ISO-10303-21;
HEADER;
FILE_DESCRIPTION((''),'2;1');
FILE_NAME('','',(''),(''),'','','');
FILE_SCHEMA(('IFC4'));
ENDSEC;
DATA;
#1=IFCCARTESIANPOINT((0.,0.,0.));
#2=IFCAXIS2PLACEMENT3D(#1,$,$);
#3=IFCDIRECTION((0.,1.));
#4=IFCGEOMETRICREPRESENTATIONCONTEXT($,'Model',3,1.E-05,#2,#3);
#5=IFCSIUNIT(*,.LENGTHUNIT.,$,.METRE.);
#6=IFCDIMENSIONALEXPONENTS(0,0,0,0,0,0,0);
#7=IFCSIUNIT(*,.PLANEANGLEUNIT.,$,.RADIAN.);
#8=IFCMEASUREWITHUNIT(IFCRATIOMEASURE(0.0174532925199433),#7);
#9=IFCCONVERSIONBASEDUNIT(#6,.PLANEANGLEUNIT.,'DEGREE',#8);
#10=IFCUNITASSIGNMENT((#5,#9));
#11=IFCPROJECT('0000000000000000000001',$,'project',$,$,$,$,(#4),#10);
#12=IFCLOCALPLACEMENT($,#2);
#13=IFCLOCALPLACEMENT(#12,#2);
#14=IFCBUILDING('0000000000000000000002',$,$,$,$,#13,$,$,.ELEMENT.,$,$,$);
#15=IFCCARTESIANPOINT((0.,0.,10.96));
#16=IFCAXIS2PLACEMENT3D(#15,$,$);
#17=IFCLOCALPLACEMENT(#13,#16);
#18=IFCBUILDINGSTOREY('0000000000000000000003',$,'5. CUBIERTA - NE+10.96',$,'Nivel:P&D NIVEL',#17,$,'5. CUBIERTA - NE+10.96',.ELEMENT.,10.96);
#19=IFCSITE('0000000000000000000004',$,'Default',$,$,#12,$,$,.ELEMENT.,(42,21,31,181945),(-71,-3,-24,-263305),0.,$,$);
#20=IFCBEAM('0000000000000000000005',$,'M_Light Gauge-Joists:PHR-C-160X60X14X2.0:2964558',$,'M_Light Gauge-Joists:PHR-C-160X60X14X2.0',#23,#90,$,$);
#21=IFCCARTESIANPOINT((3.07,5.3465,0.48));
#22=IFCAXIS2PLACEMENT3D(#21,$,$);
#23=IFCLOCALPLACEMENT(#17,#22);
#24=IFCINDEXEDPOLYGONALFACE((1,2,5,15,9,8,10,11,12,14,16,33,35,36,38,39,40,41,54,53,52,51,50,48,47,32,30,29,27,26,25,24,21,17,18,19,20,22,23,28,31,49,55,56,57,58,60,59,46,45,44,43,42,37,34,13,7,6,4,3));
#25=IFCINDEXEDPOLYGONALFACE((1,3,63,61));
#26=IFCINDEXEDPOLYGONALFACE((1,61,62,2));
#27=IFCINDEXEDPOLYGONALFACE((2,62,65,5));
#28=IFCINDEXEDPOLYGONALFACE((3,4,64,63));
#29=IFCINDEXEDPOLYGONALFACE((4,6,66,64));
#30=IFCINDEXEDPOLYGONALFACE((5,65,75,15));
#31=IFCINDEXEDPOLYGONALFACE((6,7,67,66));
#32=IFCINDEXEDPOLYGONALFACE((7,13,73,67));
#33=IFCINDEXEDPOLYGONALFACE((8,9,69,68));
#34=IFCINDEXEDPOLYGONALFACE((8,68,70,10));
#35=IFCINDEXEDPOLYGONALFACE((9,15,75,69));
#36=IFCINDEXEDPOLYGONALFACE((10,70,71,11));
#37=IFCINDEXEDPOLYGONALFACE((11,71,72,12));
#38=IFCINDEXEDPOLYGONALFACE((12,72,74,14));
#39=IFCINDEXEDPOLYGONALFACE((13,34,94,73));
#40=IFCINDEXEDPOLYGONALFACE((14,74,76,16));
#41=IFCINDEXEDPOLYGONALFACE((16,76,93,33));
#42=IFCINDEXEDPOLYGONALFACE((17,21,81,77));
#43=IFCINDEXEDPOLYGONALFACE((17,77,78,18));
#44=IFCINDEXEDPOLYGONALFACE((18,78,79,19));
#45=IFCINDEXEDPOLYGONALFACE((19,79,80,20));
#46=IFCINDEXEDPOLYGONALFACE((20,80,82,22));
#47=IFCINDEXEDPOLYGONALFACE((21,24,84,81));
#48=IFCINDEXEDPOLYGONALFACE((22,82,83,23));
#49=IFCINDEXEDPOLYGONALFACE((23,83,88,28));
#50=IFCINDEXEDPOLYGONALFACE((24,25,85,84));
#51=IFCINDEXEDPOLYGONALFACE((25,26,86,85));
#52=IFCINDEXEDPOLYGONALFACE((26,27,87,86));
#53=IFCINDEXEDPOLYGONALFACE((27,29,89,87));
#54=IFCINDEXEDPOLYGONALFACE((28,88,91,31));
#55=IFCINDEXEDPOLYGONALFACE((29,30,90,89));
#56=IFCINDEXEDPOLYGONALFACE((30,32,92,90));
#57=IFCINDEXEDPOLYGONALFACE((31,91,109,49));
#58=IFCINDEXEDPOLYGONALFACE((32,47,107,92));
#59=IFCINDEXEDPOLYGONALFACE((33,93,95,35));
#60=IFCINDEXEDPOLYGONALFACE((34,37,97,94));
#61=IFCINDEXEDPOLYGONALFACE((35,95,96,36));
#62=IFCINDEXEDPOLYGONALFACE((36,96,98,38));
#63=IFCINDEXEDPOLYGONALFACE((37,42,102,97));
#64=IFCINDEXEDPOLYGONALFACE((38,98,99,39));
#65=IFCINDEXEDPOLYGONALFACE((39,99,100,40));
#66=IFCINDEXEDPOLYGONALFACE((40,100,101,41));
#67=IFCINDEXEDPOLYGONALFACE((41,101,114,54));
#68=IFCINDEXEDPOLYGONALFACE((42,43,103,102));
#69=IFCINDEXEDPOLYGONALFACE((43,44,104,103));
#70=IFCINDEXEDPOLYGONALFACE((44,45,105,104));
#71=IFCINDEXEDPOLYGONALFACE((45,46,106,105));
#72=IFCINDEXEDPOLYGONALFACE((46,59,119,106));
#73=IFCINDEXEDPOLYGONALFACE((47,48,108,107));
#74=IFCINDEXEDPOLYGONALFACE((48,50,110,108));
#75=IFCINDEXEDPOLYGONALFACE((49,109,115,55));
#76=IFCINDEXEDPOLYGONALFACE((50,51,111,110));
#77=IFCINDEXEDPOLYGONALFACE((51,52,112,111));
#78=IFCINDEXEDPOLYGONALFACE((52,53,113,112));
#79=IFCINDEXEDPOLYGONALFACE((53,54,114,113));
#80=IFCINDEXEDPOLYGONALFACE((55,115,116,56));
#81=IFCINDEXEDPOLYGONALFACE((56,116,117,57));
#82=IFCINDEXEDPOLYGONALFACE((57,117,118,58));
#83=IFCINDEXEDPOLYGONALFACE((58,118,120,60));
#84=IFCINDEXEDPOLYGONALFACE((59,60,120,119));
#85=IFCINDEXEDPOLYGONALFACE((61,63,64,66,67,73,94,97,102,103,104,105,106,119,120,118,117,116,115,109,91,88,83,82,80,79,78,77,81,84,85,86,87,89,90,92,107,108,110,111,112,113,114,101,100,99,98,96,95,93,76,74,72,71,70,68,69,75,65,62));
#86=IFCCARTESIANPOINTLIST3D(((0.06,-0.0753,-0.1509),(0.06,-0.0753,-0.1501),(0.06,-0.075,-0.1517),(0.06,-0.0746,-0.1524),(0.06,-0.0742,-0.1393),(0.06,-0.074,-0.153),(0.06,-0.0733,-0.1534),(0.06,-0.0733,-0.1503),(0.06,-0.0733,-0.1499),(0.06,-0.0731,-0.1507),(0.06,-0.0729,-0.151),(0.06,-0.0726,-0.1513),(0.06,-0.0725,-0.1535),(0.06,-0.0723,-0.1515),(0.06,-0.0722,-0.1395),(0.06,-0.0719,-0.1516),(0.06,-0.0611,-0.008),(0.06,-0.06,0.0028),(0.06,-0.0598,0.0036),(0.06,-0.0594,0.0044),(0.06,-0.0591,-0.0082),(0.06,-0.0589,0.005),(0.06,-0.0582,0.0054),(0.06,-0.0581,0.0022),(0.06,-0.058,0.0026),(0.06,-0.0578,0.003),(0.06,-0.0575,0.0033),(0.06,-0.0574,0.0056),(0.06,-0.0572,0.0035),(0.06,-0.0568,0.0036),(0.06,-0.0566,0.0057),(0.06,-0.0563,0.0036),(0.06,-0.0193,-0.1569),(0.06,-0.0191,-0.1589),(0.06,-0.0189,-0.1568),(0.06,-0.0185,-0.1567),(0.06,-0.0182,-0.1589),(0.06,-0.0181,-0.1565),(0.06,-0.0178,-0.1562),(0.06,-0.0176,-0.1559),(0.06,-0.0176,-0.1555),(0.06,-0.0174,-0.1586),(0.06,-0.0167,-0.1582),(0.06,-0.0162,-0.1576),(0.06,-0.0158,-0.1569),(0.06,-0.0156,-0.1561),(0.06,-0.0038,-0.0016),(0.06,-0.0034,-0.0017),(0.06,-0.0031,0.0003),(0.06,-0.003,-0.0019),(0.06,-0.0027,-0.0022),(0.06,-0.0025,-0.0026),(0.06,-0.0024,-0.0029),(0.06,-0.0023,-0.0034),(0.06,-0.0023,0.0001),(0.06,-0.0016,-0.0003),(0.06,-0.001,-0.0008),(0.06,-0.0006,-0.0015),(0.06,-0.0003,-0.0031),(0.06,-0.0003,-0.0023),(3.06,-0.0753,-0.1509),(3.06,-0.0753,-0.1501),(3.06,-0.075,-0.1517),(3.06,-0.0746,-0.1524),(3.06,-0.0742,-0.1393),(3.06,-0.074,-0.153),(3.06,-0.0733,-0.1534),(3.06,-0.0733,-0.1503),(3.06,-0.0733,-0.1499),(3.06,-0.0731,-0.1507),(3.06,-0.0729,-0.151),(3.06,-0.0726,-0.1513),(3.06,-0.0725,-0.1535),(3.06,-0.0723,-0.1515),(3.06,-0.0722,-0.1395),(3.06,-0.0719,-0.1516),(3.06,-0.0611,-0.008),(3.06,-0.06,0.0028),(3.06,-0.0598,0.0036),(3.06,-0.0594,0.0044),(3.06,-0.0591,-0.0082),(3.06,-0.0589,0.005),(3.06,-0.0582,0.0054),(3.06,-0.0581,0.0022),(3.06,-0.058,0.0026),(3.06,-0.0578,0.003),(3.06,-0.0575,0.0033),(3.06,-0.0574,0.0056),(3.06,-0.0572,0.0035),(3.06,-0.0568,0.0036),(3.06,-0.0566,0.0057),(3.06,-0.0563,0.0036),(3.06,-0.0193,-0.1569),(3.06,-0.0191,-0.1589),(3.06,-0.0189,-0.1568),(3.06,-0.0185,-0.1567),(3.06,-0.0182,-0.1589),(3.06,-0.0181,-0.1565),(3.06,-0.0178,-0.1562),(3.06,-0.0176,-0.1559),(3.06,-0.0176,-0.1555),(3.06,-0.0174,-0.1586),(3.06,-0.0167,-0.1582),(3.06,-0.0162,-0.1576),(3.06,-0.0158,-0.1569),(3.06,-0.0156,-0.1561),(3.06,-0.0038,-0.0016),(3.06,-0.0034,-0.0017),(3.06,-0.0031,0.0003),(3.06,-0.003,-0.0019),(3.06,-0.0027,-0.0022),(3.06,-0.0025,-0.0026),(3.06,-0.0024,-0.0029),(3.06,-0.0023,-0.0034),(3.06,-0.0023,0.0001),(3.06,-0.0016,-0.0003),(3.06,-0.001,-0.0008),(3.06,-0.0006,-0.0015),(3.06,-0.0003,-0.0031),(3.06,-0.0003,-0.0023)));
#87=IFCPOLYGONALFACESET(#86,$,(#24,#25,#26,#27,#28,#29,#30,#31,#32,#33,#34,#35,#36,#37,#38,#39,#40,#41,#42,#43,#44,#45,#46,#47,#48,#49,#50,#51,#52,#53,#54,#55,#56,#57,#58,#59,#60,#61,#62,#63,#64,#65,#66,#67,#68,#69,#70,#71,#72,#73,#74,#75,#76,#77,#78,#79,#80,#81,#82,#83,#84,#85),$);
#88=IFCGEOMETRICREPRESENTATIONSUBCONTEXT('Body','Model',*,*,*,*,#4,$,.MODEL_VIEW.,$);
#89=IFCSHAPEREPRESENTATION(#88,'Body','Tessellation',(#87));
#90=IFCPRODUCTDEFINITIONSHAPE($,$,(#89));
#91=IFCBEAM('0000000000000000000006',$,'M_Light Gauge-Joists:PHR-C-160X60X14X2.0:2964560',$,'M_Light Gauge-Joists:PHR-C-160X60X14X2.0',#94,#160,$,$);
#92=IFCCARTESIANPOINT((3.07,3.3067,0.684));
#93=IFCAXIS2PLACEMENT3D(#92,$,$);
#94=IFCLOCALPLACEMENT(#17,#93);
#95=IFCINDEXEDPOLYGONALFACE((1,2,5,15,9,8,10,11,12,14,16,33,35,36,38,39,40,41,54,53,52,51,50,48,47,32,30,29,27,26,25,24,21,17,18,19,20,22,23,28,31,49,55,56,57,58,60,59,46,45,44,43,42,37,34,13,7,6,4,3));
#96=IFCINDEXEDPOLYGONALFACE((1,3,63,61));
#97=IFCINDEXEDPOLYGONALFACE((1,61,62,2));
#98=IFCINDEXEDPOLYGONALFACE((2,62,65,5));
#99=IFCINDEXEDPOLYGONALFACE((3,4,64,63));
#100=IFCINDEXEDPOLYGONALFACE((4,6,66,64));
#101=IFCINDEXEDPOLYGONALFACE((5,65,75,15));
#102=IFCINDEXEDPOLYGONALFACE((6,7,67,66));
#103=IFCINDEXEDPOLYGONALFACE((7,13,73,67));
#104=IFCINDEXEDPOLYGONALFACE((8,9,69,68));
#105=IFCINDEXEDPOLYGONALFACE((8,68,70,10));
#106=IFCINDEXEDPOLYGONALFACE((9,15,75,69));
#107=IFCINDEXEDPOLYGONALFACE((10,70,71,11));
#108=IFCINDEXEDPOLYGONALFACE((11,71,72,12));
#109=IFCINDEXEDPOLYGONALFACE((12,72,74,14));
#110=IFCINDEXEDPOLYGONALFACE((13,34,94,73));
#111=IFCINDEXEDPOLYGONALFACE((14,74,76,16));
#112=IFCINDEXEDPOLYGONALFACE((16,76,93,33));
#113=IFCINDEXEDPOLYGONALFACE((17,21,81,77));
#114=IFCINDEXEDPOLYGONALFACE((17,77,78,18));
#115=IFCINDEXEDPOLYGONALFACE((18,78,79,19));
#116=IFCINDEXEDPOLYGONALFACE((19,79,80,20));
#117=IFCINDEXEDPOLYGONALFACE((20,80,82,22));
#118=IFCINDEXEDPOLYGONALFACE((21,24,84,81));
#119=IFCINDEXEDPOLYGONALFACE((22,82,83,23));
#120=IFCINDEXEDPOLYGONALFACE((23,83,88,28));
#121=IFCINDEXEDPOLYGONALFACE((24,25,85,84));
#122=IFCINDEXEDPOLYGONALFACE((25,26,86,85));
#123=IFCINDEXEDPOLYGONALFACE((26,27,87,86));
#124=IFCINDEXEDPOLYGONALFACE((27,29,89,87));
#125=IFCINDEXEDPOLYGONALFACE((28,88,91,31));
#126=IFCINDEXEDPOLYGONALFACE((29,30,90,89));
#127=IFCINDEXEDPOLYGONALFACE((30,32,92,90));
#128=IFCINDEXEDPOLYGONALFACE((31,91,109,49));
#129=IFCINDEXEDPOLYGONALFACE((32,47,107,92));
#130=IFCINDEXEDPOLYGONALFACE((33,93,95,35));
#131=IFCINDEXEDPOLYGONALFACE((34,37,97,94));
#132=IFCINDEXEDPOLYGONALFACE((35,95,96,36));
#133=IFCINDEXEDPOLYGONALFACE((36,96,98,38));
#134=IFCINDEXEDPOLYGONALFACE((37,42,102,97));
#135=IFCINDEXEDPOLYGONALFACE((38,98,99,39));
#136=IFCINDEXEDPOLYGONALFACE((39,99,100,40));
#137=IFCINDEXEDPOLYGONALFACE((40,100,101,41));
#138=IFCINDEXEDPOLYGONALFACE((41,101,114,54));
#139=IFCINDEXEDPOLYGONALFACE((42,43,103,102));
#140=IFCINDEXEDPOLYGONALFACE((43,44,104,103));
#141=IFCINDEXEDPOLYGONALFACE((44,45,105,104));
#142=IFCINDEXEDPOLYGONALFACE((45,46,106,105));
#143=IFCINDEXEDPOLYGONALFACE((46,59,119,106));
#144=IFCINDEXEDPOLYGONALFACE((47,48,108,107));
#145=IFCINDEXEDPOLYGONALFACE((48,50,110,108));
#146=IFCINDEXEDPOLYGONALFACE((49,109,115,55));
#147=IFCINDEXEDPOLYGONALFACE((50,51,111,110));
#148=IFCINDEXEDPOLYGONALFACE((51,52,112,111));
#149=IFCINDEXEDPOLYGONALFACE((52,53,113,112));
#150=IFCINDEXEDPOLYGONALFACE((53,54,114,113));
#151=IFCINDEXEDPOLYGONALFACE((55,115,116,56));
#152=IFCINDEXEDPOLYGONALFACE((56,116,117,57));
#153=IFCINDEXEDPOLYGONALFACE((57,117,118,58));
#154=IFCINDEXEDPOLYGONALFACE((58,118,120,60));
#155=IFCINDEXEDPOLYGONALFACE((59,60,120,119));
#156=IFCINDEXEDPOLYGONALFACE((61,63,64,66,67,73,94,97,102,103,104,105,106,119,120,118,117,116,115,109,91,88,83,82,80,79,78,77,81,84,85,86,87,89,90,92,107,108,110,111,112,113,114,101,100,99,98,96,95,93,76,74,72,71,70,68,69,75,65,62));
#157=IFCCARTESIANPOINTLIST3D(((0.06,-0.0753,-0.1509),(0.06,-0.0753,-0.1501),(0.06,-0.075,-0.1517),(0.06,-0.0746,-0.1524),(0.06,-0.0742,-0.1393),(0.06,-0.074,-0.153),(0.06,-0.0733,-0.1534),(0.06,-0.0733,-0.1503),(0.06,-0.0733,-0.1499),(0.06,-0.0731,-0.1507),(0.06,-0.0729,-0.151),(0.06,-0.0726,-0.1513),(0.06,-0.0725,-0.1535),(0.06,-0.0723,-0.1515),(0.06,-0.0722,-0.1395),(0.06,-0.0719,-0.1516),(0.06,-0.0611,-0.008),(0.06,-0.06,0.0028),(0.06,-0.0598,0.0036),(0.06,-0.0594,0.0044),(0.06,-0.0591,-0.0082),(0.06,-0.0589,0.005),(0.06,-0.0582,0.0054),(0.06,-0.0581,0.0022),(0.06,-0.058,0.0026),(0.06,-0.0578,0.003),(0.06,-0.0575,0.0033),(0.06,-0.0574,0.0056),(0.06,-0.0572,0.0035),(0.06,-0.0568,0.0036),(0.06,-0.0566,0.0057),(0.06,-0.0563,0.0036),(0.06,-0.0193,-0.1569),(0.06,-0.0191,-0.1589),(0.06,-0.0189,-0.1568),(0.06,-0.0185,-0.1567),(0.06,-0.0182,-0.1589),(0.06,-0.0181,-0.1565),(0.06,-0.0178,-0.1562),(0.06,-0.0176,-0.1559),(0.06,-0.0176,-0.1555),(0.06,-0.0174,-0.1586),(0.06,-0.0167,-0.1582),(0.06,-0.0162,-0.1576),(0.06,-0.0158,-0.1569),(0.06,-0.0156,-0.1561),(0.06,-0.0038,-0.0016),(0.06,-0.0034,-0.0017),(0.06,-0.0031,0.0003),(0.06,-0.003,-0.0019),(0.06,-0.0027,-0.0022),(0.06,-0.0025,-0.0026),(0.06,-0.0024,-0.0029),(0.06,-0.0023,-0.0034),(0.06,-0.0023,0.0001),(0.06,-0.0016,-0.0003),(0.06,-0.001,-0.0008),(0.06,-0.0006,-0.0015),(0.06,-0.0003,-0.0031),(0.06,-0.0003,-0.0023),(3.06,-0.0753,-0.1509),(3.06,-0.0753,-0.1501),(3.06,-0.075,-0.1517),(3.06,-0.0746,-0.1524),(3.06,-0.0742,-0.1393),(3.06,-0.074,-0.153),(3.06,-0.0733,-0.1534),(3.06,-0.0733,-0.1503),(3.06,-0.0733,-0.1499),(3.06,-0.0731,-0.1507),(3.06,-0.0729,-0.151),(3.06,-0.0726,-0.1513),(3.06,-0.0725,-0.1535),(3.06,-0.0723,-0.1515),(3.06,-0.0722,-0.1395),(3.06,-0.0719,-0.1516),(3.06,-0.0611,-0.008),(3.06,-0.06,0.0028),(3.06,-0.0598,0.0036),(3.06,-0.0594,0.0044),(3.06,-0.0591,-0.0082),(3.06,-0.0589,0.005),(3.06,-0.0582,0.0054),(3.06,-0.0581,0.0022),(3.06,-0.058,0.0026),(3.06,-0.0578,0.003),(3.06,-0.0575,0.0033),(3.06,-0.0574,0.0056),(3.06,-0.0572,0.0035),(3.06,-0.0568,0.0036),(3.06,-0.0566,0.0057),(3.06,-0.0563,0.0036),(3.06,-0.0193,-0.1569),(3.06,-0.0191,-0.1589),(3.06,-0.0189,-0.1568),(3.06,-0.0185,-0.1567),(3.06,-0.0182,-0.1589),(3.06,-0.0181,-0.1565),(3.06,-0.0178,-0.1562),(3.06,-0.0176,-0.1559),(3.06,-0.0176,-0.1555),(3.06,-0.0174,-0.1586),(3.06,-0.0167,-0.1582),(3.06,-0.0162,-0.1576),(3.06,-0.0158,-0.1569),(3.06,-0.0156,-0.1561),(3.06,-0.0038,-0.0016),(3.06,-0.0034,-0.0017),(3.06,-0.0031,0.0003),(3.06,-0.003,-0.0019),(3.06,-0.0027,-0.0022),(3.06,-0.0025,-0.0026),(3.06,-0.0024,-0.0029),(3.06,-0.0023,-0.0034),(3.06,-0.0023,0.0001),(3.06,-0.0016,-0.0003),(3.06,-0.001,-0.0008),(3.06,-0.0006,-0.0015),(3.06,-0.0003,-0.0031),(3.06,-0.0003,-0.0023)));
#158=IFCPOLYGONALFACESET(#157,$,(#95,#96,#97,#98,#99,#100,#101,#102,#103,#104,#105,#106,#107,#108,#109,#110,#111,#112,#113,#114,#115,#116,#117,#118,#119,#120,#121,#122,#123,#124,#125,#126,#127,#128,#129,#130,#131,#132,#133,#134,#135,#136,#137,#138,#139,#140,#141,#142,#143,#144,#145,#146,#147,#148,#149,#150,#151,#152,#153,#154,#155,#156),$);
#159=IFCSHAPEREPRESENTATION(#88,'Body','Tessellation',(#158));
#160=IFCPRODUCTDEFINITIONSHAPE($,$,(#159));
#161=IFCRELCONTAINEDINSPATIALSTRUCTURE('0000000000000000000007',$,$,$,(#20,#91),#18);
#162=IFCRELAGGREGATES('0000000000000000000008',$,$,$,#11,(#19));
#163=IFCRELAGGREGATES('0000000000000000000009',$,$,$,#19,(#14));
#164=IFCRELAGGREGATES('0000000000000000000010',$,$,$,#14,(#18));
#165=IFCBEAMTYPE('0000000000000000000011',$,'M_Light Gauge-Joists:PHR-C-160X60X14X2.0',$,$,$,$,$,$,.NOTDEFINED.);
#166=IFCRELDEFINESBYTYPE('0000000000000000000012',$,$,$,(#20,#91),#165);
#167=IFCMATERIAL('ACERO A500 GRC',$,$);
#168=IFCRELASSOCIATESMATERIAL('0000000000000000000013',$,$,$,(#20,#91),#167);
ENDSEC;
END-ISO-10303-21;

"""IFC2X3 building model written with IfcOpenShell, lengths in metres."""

from ifc_helpers import new_model, entity, si_unit, converted_unit, direction, frame, frame_2d, origin, place, context, subcontext, project, spatial, polyline, circle_curve, parameter, trimmed, segment, composite_curve, outline, extrude, material, type_object, element, save


model = new_model("IFC2X3")

# Units and contexts
model_context = context("Model", 3, precision=1e-05, world=origin(), true_north=direction((0.0, 1.0)))
body_context = subcontext(model_context, "Body", "Model", "MODEL_VIEW")
ifc_project = project(units=[si_unit("LENGTHUNIT", "METRE"), converted_unit("PLANEANGLEUNIT", "DEGREE", entity("IfcRatioMeasure", 0.0174532925199433), si_unit("PLANEANGLEUNIT", "RADIAN"), dimensions=[0, 0, 0, 0, 0, 0, 0])], contexts=[model_context])

# Site, building, storey
site_placement = place(None, origin())
site = spatial("IfcSite", under=ifc_project, at=site_placement, Name="Default", CompositionType="ELEMENT", RefLatitude=(42, 21, 31, 181945), RefLongitude=(-71, -3, -24, -263305), RefElevation=0.0)
building_placement = place(site_placement, origin())
building = spatial("IfcBuilding", under=site, at=building_placement, CompositionType="ELEMENT")
storey_placement = place(building_placement, frame((0.0, 0.0, 10.96)))
storey = spatial("IfcBuildingStorey", under=building, at=storey_placement, Name="5. CUBIERTA - NE+10.96", ObjectType="Nivel:P&D NIVEL", LongName="5. CUBIERTA - NE+10.96", CompositionType="ELEMENT", Elevation=10.96)

# Beams
ifc_material_1 = material(Name="ACERO A500 GRC")
beam_type_1 = type_object("IfcBeamType", Name="M_Light Gauge-Joists:PHR-C-160X60X14X2.0", PredefinedType="NOTDEFINED")
beam_1_placement = place(storey_placement, frame((3.07, 5.3465, 0.48)))
element("IfcBeam", 1, at=beam_1_placement, inside=storey, type_object=beam_type_1, material=ifc_material_1, Name="M_Light Gauge-Joists:PHR-C-160X60X14X2.0:2964558", ObjectType="M_Light Gauge-Joists:PHR-C-160X60X14X2.0", context=body_context, shape_type="SweptSolid", body=[
    extrude(outline(composite_curve([segment(polyline([(-0.0768, -0.0358), (0.0768, -0.0358)]), True, "CONTINUOUS"), segment(trimmed(circle_curve(frame_2d((0.0768, -0.0326), x_axis=(0.0, -1.0)), 0.0032), [parameter(0.0)], [parameter(90.0)], True, "PARAMETER"), True, "CONTINUOUS"), segment(polyline([(0.08, -0.0326), (0.08, 0.021)]), True, "CONTINUOUS"), segment(trimmed(circle_curve(frame_2d((0.0768, 0.021), x_axis=(1.0, 0.0)), 0.0032), [parameter(0.0)], [parameter(90.0)], True, "PARAMETER"), True, "CONTINUOUS"), segment(polyline([(0.0768, 0.0242), (0.066, 0.0242)]), True, "CONTINUOUS"), segment(polyline([(0.066, 0.0242), (0.066, 0.0222)]), True, "CONTINUOUS"), segment(polyline([(0.066, 0.0222), (0.0764, 0.0222)]), True, "CONTINUOUS"), segment(trimmed(circle_curve(frame_2d((0.0764, 0.0206), x_axis=(0.0, 1.0)), 0.0016), [parameter(270.0)], [parameter(0.0)], True, "PARAMETER"), False, "CONTINUOUS"), segment(polyline([(0.078, 0.0206), (0.078, -0.0322)]), True, "CONTINUOUS"), segment(trimmed(circle_curve(frame_2d((0.0764, -0.0322), x_axis=(1.0, 0.0)), 0.0016), [parameter(270.0)], [parameter(0.0)], True, "PARAMETER"), False, "CONTINUOUS"), segment(polyline([(0.0764, -0.0338), (-0.0764, -0.0338)]), True, "CONTINUOUS"), segment(trimmed(circle_curve(frame_2d((-0.0764, -0.0322), x_axis=(0.0, -1.0)), 0.0016), [parameter(270.0)], [parameter(0.0)], True, "PARAMETER"), False, "CONTINUOUS"), segment(polyline([(-0.078, -0.0322), (-0.078, 0.0206)]), True, "CONTINUOUS"), segment(trimmed(circle_curve(frame_2d((-0.0764, 0.0206), x_axis=(-1.0, 0.0)), 0.0016), [parameter(270.0)], [parameter(0.0)], True, "PARAMETER"), False, "CONTINUOUS"), segment(polyline([(-0.0764, 0.0222), (-0.066, 0.0222)]), True, "CONTINUOUS"), segment(polyline([(-0.066, 0.0222), (-0.066, 0.0242)]), True, "CONTINUOUS"), segment(polyline([(-0.066, 0.0242), (-0.0768, 0.0242)]), True, "CONTINUOUS"), segment(trimmed(circle_curve(frame_2d((-0.0768, 0.021), x_axis=(0.0, 1.0)), 0.0032), [parameter(0.0)], [parameter(90.0)], True, "PARAMETER"), True, "CONTINUOUS"), segment(polyline([(-0.08, 0.021), (-0.08, -0.0326)]), True, "CONTINUOUS"), segment(trimmed(circle_curve(frame_2d((-0.0768, -0.0326), x_axis=(-1.0, 0.0)), 0.0032), [parameter(0.0)], [parameter(90.0)], True, "PARAMETER"), True, "CONTINUOUS")], self_intersect=False)), frame((0.06, -0.0436, -0.076), z_axis=(1.0, 0.0, 0.0), x_axis=(0.0, 0.099504, 0.995037)), (0.0, 0.0, 1.0), 3.0),
])
beam_2_placement = place(storey_placement, frame((3.07, 3.3067, 0.684)))
element("IfcBeam", 2, at=beam_2_placement, inside=storey, type_object=beam_type_1, material=ifc_material_1, Name="M_Light Gauge-Joists:PHR-C-160X60X14X2.0:2964560", ObjectType="M_Light Gauge-Joists:PHR-C-160X60X14X2.0", context=body_context, shape_type="SweptSolid", body=[
    extrude(outline(composite_curve([segment(polyline([(-0.0768, -0.0358), (0.0768, -0.0358)]), True, "CONTINUOUS"), segment(trimmed(circle_curve(frame_2d((0.0768, -0.0326), x_axis=(0.0, -1.0)), 0.0032), [parameter(0.0)], [parameter(90.0)], True, "PARAMETER"), True, "CONTINUOUS"), segment(polyline([(0.08, -0.0326), (0.08, 0.021)]), True, "CONTINUOUS"), segment(trimmed(circle_curve(frame_2d((0.0768, 0.021), x_axis=(1.0, 0.0)), 0.0032), [parameter(0.0)], [parameter(90.0)], True, "PARAMETER"), True, "CONTINUOUS"), segment(polyline([(0.0768, 0.0242), (0.066, 0.0242)]), True, "CONTINUOUS"), segment(polyline([(0.066, 0.0242), (0.066, 0.0222)]), True, "CONTINUOUS"), segment(polyline([(0.066, 0.0222), (0.0764, 0.0222)]), True, "CONTINUOUS"), segment(trimmed(circle_curve(frame_2d((0.0764, 0.0206), x_axis=(0.0, 1.0)), 0.0016), [parameter(270.0)], [parameter(0.0)], True, "PARAMETER"), False, "CONTINUOUS"), segment(polyline([(0.078, 0.0206), (0.078, -0.0322)]), True, "CONTINUOUS"), segment(trimmed(circle_curve(frame_2d((0.0764, -0.0322), x_axis=(1.0, 0.0)), 0.0016), [parameter(270.0)], [parameter(0.0)], True, "PARAMETER"), False, "CONTINUOUS"), segment(polyline([(0.0764, -0.0338), (-0.0764, -0.0338)]), True, "CONTINUOUS"), segment(trimmed(circle_curve(frame_2d((-0.0764, -0.0322), x_axis=(0.0, -1.0)), 0.0016), [parameter(270.0)], [parameter(0.0)], True, "PARAMETER"), False, "CONTINUOUS"), segment(polyline([(-0.078, -0.0322), (-0.078, 0.0206)]), True, "CONTINUOUS"), segment(trimmed(circle_curve(frame_2d((-0.0764, 0.0206), x_axis=(-1.0, 0.0)), 0.0016), [parameter(270.0)], [parameter(0.0)], True, "PARAMETER"), False, "CONTINUOUS"), segment(polyline([(-0.0764, 0.0222), (-0.066, 0.0222)]), True, "CONTINUOUS"), segment(polyline([(-0.066, 0.0222), (-0.066, 0.0242)]), True, "CONTINUOUS"), segment(polyline([(-0.066, 0.0242), (-0.0768, 0.0242)]), True, "CONTINUOUS"), segment(trimmed(circle_curve(frame_2d((-0.0768, 0.021), x_axis=(0.0, 1.0)), 0.0032), [parameter(0.0)], [parameter(90.0)], True, "PARAMETER"), True, "CONTINUOUS"), segment(polyline([(-0.08, 0.021), (-0.08, -0.0326)]), True, "CONTINUOUS"), segment(trimmed(circle_curve(frame_2d((-0.0768, -0.0326), x_axis=(-1.0, 0.0)), 0.0032), [parameter(0.0)], [parameter(90.0)], True, "PARAMETER"), True, "CONTINUOUS")], self_intersect=False)), frame((0.06, -0.0436, -0.076), z_axis=(1.0, 0.0, 0.0), x_axis=(0.0, 0.099504, 0.995037)), (0.0, 0.0, 1.0), 3.0),
])

save(model, "model.ifc")
